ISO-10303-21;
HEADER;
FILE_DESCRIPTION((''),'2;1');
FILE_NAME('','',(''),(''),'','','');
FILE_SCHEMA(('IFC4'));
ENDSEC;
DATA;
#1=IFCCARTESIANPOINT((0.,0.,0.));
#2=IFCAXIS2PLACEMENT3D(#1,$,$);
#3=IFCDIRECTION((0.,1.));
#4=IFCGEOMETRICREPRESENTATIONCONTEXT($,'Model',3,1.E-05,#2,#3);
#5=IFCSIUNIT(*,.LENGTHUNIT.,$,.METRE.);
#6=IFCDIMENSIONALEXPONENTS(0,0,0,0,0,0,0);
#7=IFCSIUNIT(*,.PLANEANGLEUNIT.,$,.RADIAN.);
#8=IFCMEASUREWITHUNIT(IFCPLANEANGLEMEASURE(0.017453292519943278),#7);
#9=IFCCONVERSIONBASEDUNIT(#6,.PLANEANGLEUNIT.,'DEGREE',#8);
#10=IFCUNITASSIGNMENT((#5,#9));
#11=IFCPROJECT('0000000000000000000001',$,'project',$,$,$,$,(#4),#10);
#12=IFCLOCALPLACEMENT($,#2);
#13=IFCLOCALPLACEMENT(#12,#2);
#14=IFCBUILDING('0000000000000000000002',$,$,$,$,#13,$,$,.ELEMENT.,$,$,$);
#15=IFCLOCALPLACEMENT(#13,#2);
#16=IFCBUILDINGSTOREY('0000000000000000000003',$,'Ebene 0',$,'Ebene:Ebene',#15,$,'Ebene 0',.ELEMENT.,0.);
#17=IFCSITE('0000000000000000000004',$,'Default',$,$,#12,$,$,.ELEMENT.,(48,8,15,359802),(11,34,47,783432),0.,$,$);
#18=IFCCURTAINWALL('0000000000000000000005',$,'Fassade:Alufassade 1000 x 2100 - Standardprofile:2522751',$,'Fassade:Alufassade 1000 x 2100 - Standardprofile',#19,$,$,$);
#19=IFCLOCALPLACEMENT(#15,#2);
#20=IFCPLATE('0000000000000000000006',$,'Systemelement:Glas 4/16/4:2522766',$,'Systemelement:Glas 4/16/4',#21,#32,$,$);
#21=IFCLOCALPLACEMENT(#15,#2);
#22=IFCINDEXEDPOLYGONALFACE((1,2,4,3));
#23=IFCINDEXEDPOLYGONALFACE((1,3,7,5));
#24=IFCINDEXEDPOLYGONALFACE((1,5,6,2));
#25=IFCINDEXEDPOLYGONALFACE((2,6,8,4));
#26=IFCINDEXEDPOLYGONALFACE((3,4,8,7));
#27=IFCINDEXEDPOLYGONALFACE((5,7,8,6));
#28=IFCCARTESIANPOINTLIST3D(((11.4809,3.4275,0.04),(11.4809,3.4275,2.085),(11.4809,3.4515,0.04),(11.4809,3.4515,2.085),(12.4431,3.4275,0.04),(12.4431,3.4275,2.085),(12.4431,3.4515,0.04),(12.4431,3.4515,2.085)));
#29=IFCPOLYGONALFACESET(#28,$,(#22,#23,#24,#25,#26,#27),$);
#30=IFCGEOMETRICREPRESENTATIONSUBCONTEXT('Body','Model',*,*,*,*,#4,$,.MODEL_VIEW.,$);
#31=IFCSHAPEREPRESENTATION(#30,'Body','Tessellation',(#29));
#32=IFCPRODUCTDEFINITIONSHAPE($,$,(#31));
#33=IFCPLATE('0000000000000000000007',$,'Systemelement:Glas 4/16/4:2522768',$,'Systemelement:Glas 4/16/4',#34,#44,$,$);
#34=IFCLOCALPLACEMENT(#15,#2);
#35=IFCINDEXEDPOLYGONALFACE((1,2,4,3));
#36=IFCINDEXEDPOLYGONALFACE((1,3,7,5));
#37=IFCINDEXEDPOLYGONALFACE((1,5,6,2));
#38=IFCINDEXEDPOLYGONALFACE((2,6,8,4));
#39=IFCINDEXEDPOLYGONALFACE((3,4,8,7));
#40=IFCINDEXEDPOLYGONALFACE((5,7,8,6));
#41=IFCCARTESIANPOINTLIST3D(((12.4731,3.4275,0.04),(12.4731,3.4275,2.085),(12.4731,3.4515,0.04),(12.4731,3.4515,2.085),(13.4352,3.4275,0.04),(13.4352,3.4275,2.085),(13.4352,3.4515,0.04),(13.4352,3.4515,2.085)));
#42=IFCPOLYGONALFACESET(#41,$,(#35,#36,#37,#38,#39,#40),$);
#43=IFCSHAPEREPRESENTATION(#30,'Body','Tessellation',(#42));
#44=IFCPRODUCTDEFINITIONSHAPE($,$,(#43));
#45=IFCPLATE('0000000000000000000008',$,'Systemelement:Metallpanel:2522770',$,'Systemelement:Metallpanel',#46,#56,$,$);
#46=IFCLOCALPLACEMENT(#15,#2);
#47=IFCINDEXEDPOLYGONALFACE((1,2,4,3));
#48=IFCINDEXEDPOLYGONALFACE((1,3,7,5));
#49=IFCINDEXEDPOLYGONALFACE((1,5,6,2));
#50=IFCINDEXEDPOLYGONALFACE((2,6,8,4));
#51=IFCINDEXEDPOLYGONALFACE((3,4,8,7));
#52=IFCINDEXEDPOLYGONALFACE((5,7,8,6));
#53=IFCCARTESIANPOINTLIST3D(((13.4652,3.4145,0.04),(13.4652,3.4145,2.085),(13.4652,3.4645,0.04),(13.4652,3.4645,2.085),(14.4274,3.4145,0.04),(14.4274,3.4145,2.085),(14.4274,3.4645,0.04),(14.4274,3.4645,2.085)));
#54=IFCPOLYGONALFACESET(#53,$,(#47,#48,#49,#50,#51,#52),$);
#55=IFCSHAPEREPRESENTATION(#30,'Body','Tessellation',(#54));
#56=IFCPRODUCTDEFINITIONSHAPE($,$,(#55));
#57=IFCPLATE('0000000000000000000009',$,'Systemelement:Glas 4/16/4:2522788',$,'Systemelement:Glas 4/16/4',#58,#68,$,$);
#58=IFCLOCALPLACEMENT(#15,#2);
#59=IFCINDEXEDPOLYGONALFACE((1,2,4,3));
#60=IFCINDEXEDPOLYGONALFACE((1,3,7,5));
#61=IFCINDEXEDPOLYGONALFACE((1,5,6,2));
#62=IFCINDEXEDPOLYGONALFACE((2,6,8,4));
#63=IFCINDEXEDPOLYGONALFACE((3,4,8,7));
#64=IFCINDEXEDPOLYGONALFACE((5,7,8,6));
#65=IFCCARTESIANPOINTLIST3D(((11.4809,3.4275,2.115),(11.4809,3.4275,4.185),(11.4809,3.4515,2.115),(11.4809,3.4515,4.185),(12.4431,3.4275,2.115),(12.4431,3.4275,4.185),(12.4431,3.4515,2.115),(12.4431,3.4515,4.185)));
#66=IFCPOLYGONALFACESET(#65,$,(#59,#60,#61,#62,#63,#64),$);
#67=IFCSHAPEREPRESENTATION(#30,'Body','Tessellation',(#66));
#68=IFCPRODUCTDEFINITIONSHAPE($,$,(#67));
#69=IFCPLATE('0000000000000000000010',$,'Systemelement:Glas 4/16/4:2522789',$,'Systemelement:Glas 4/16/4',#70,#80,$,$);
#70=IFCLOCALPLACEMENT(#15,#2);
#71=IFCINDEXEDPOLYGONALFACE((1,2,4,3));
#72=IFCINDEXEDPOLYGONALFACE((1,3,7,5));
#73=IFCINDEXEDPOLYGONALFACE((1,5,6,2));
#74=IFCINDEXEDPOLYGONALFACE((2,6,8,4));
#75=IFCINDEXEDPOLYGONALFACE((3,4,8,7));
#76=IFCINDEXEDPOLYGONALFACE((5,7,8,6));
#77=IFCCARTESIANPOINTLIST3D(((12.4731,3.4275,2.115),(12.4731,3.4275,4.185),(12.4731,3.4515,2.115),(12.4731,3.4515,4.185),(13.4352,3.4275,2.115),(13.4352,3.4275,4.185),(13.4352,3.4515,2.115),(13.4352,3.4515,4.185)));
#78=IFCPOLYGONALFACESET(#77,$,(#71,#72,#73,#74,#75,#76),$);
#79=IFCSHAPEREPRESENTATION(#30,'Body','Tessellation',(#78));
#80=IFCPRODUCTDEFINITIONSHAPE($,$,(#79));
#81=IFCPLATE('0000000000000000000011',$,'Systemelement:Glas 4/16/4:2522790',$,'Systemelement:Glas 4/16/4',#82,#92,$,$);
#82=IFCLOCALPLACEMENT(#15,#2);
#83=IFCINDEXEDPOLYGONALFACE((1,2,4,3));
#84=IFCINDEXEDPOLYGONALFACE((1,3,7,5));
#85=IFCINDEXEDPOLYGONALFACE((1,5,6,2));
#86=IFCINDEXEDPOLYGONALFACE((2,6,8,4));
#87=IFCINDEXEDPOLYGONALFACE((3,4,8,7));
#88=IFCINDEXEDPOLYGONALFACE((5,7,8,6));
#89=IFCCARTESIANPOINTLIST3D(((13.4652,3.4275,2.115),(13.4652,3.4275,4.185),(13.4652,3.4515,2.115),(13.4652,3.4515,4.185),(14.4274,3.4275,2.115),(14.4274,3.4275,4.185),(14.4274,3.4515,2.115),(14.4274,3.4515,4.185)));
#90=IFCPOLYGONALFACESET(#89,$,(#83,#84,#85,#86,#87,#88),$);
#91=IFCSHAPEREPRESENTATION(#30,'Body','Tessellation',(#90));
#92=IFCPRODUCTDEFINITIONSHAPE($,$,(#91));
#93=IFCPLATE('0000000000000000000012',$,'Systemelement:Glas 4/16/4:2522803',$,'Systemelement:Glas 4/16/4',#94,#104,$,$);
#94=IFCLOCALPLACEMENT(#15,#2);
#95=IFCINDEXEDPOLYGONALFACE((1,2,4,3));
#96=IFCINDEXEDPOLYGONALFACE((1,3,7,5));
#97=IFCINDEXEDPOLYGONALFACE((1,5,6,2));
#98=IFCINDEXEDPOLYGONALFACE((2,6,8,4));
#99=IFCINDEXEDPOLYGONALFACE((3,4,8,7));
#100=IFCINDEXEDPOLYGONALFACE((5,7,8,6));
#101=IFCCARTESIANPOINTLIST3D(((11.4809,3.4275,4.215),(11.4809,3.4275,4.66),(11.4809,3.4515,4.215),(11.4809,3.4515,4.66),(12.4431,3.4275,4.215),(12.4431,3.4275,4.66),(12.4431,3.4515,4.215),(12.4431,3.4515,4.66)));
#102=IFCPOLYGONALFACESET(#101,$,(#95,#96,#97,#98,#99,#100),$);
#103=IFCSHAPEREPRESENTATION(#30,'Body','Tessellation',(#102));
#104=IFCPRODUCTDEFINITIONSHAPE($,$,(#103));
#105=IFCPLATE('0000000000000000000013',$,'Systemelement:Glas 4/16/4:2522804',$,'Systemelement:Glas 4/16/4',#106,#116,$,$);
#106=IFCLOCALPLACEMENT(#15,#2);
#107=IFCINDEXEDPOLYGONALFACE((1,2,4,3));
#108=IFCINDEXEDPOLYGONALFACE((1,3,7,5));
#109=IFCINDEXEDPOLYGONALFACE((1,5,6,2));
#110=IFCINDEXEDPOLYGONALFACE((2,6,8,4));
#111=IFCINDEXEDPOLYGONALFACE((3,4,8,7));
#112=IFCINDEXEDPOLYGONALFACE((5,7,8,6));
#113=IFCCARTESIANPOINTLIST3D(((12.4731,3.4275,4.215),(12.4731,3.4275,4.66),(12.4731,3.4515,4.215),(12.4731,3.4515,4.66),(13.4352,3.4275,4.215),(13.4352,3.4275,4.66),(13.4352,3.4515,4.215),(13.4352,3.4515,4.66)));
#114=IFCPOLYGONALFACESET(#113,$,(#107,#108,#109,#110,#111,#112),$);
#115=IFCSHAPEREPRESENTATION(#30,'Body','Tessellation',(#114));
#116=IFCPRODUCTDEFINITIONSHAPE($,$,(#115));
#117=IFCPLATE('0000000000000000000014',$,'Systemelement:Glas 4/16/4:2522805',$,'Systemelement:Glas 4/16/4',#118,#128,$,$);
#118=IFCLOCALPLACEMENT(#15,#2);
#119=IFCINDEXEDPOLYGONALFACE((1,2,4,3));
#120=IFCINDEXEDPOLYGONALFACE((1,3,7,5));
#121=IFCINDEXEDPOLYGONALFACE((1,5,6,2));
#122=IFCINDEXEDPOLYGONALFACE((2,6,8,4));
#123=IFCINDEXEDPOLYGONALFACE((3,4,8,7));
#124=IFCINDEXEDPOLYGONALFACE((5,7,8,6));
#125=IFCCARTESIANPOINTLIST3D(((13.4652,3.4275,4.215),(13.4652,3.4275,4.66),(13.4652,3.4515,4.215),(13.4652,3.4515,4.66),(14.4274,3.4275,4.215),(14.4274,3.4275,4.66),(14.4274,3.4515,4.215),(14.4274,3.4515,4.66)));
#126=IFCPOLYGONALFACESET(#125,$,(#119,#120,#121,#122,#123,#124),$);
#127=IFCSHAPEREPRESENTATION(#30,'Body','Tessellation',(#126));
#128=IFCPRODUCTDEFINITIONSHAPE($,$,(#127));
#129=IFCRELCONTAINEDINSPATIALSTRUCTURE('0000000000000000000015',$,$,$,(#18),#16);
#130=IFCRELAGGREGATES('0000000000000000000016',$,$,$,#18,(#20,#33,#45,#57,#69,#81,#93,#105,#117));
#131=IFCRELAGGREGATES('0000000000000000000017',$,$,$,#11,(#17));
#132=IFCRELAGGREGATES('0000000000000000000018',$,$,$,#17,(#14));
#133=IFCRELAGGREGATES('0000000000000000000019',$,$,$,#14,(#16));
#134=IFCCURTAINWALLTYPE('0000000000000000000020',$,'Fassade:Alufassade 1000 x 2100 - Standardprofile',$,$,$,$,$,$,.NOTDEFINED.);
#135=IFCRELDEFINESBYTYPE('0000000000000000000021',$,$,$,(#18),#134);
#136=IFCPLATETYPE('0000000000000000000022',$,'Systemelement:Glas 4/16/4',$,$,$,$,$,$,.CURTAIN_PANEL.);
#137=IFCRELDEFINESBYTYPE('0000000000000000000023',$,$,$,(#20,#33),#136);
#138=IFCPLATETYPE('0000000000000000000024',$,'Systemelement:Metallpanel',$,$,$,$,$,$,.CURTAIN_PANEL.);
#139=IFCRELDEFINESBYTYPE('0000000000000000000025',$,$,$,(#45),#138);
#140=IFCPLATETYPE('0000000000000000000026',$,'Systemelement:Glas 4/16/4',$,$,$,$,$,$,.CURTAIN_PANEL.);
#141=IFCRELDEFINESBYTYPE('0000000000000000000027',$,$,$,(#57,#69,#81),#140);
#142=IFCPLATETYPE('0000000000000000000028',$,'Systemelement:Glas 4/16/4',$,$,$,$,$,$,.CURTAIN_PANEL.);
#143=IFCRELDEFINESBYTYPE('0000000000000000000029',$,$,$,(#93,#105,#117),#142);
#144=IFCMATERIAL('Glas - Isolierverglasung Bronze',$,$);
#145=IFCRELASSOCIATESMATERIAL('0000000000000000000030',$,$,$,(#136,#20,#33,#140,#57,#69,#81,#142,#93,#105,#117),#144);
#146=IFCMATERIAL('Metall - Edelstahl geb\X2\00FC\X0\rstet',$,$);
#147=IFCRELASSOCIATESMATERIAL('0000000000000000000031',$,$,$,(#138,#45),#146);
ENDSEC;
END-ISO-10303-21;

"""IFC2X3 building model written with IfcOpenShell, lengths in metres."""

from ifc_helpers import new_model, entity, si_unit, converted_unit, direction, frame, origin, origin_2d_with_axis, place, context, subcontext, project, spatial, rectangle, extrude, source, transform, mapped, material, type_object, type_shapes, element, aggregate, save


model = new_model("IFC2X3")

# Units and contexts
model_context = context("Model", 3, precision=1e-05, world=origin(), true_north=direction((0.0, 1.0)))
body_context = subcontext(model_context, "Body", "Model", "MODEL_VIEW")
ifc_project = project(units=[si_unit("LENGTHUNIT", "METRE"), converted_unit("PLANEANGLEUNIT", "DEGREE", entity("IfcPlaneAngleMeasure", 0.017453292519943278), si_unit("PLANEANGLEUNIT", "RADIAN"), dimensions=[0, 0, 0, 0, 0, 0, 0])], contexts=[model_context])

# Site, building, storey
site_placement = place(None, origin())
site = spatial("IfcSite", under=ifc_project, at=site_placement, Name="Default", CompositionType="ELEMENT", RefLatitude=(48, 8, 15, 359802), RefLongitude=(11, 34, 47, 783432), RefElevation=0.0)
building_placement = place(site_placement, origin())
building = spatial("IfcBuilding", under=site, at=building_placement, CompositionType="ELEMENT")
storey_placement = place(building_placement, origin())
storey = spatial("IfcBuildingStorey", under=building, at=storey_placement, Name="Ebene 0", ObjectType="Ebene:Ebene", LongName="Ebene 0", CompositionType="ELEMENT", Elevation=0.0)

# Curtain wall, plates
curtain_wall_type = type_object("IfcCurtainWallType", Name="Fassade:Alufassade 1000 x 2100 - Standardprofile", PredefinedType="NOTDEFINED")
curtain_wall_placement = place(storey_placement, origin())
curtain_wall = element("IfcCurtainWall", 1, at=curtain_wall_placement, inside=storey, type_object=curtain_wall_type, Name="Fassade:Alufassade 1000 x 2100 - Standardprofile:2522751", ObjectType="Fassade:Alufassade 1000 x 2100 - Standardprofile")
ifc_material_1 = material(Name="Glas - Isolierverglasung Bronze")
plate_type_1 = type_object("IfcPlateType", Name="Systemelement:Glas 4/16/4", PredefinedType="CURTAIN_PANEL", material=ifc_material_1)
shared_shape_1 = source(origin(), body_context, "Body", "SweptSolid", [
    extrude(rectangle(XDim=0.024, YDim=0.9621, at=origin_2d_with_axis()), frame((0.0, 0.0, 0.0), z_axis=(0.0, 0.0, 1.0), x_axis=(0.0, 1.0, 0.0)), (0.0, 0.0, 1.0), 2.045),
])
type_shapes(plate_type_1, [shared_shape_1])
plate_1_placement = place(curtain_wall_placement, frame((11.962, 3.4395, 0.04)))
plate_1 = element("IfcPlate", 2, at=plate_1_placement, type_object=plate_type_1, material=ifc_material_1, Name="Systemelement:Glas 4/16/4:2522766", ObjectType="Systemelement:Glas 4/16/4", context=body_context, shape_type="MappedRepresentation", body=[
    mapped(shared_shape_1, transform((0.0, 0.0, 0.0), scale=1.0)),
])
plate_2_placement = place(curtain_wall_placement, frame((12.9542, 3.4395, 0.04)))
plate_2 = element("IfcPlate", 3, at=plate_2_placement, type_object=plate_type_1, material=ifc_material_1, Name="Systemelement:Glas 4/16/4:2522768", ObjectType="Systemelement:Glas 4/16/4", context=body_context, shape_type="MappedRepresentation", body=[
    mapped(shared_shape_1, transform((0.0, 0.0, 0.0), scale=1.0)),
])
ifc_material_2 = material(Name="Metall - Edelstahl gebürstet")
plate_type_2 = type_object("IfcPlateType", Name="Systemelement:Metallpanel", PredefinedType="CURTAIN_PANEL", material=ifc_material_2)
shared_shape_2 = source(origin(), body_context, "Body", "SweptSolid", [
    extrude(rectangle(XDim=0.05, YDim=0.9621, at=origin_2d_with_axis()), frame((0.0, 0.0, 0.0), z_axis=(0.0, 0.0, 1.0), x_axis=(0.0, 1.0, 0.0)), (0.0, 0.0, 1.0), 2.045),
])
type_shapes(plate_type_2, [shared_shape_2])
plate_3_placement = place(curtain_wall_placement, frame((13.9463, 3.4395, 0.04)))
plate_3 = element("IfcPlate", 4, at=plate_3_placement, type_object=plate_type_2, material=ifc_material_2, Name="Systemelement:Metallpanel:2522770", ObjectType="Systemelement:Metallpanel", context=body_context, shape_type="MappedRepresentation", body=[
    mapped(shared_shape_2, transform((0.0, 0.0, 0.0), scale=1.0)),
])
plate_type_3 = type_object("IfcPlateType", Name="Systemelement:Glas 4/16/4", PredefinedType="CURTAIN_PANEL", material=ifc_material_1)
shared_shape_3 = source(origin(), body_context, "Body", "SweptSolid", [
    extrude(rectangle(XDim=0.024, YDim=0.9621, at=origin_2d_with_axis()), frame((0.0, 0.0, 0.0), z_axis=(0.0, 0.0, 1.0), x_axis=(0.0, 1.0, 0.0)), (0.0, 0.0, 1.0), 2.07),
])
type_shapes(plate_type_3, [shared_shape_3])
plate_4_placement = place(curtain_wall_placement, frame((11.962, 3.4395, 2.115)))
plate_4 = element("IfcPlate", 5, at=plate_4_placement, type_object=plate_type_3, material=ifc_material_1, Name="Systemelement:Glas 4/16/4:2522788", ObjectType="Systemelement:Glas 4/16/4", context=body_context, shape_type="MappedRepresentation", body=[
    mapped(shared_shape_3, transform((0.0, 0.0, 0.0), scale=1.0)),
])
plate_5_placement = place(curtain_wall_placement, frame((12.9542, 3.4395, 2.115)))
plate_5 = element("IfcPlate", 6, at=plate_5_placement, type_object=plate_type_3, material=ifc_material_1, Name="Systemelement:Glas 4/16/4:2522789", ObjectType="Systemelement:Glas 4/16/4", context=body_context, shape_type="MappedRepresentation", body=[
    mapped(shared_shape_3, transform((0.0, 0.0, 0.0), scale=1.0)),
])
plate_6_placement = place(curtain_wall_placement, frame((13.9463, 3.4395, 2.115)))
plate_6 = element("IfcPlate", 7, at=plate_6_placement, type_object=plate_type_3, material=ifc_material_1, Name="Systemelement:Glas 4/16/4:2522790", ObjectType="Systemelement:Glas 4/16/4", context=body_context, shape_type="MappedRepresentation", body=[
    mapped(shared_shape_3, transform((0.0, 0.0, 0.0), scale=1.0)),
])
plate_type_4 = type_object("IfcPlateType", Name="Systemelement:Glas 4/16/4", PredefinedType="CURTAIN_PANEL", material=ifc_material_1)
shared_shape_4 = source(origin(), body_context, "Body", "SweptSolid", [
    extrude(rectangle(XDim=0.024, YDim=0.9621, at=origin_2d_with_axis()), frame((0.0, 0.0, 0.0), z_axis=(0.0, 0.0, 1.0), x_axis=(0.0, 1.0, 0.0)), (0.0, 0.0, 1.0), 0.445),
])
type_shapes(plate_type_4, [shared_shape_4])
plate_7_placement = place(curtain_wall_placement, frame((11.962, 3.4395, 4.215)))
plate_7 = element("IfcPlate", 8, at=plate_7_placement, type_object=plate_type_4, material=ifc_material_1, Name="Systemelement:Glas 4/16/4:2522803", ObjectType="Systemelement:Glas 4/16/4", context=body_context, shape_type="MappedRepresentation", body=[
    mapped(shared_shape_4, transform((0.0, 0.0, 0.0), scale=1.0)),
])
plate_8_placement = place(curtain_wall_placement, frame((12.9542, 3.4395, 4.215)))
plate_8 = element("IfcPlate", 9, at=plate_8_placement, type_object=plate_type_4, material=ifc_material_1, Name="Systemelement:Glas 4/16/4:2522804", ObjectType="Systemelement:Glas 4/16/4", context=body_context, shape_type="MappedRepresentation", body=[
    mapped(shared_shape_4, transform((0.0, 0.0, 0.0), scale=1.0)),
])
plate_9_placement = place(curtain_wall_placement, frame((13.9463, 3.4395, 4.215)))
plate_9 = element("IfcPlate", 10, at=plate_9_placement, type_object=plate_type_4, material=ifc_material_1, Name="Systemelement:Glas 4/16/4:2522805", ObjectType="Systemelement:Glas 4/16/4", context=body_context, shape_type="MappedRepresentation", body=[
    mapped(shared_shape_4, transform((0.0, 0.0, 0.0), scale=1.0)),
])
aggregate(curtain_wall, [plate_1, plate_2, plate_3, plate_4, plate_5, plate_6, plate_7, plate_8, plate_9])

save(model, "model.ifc")
